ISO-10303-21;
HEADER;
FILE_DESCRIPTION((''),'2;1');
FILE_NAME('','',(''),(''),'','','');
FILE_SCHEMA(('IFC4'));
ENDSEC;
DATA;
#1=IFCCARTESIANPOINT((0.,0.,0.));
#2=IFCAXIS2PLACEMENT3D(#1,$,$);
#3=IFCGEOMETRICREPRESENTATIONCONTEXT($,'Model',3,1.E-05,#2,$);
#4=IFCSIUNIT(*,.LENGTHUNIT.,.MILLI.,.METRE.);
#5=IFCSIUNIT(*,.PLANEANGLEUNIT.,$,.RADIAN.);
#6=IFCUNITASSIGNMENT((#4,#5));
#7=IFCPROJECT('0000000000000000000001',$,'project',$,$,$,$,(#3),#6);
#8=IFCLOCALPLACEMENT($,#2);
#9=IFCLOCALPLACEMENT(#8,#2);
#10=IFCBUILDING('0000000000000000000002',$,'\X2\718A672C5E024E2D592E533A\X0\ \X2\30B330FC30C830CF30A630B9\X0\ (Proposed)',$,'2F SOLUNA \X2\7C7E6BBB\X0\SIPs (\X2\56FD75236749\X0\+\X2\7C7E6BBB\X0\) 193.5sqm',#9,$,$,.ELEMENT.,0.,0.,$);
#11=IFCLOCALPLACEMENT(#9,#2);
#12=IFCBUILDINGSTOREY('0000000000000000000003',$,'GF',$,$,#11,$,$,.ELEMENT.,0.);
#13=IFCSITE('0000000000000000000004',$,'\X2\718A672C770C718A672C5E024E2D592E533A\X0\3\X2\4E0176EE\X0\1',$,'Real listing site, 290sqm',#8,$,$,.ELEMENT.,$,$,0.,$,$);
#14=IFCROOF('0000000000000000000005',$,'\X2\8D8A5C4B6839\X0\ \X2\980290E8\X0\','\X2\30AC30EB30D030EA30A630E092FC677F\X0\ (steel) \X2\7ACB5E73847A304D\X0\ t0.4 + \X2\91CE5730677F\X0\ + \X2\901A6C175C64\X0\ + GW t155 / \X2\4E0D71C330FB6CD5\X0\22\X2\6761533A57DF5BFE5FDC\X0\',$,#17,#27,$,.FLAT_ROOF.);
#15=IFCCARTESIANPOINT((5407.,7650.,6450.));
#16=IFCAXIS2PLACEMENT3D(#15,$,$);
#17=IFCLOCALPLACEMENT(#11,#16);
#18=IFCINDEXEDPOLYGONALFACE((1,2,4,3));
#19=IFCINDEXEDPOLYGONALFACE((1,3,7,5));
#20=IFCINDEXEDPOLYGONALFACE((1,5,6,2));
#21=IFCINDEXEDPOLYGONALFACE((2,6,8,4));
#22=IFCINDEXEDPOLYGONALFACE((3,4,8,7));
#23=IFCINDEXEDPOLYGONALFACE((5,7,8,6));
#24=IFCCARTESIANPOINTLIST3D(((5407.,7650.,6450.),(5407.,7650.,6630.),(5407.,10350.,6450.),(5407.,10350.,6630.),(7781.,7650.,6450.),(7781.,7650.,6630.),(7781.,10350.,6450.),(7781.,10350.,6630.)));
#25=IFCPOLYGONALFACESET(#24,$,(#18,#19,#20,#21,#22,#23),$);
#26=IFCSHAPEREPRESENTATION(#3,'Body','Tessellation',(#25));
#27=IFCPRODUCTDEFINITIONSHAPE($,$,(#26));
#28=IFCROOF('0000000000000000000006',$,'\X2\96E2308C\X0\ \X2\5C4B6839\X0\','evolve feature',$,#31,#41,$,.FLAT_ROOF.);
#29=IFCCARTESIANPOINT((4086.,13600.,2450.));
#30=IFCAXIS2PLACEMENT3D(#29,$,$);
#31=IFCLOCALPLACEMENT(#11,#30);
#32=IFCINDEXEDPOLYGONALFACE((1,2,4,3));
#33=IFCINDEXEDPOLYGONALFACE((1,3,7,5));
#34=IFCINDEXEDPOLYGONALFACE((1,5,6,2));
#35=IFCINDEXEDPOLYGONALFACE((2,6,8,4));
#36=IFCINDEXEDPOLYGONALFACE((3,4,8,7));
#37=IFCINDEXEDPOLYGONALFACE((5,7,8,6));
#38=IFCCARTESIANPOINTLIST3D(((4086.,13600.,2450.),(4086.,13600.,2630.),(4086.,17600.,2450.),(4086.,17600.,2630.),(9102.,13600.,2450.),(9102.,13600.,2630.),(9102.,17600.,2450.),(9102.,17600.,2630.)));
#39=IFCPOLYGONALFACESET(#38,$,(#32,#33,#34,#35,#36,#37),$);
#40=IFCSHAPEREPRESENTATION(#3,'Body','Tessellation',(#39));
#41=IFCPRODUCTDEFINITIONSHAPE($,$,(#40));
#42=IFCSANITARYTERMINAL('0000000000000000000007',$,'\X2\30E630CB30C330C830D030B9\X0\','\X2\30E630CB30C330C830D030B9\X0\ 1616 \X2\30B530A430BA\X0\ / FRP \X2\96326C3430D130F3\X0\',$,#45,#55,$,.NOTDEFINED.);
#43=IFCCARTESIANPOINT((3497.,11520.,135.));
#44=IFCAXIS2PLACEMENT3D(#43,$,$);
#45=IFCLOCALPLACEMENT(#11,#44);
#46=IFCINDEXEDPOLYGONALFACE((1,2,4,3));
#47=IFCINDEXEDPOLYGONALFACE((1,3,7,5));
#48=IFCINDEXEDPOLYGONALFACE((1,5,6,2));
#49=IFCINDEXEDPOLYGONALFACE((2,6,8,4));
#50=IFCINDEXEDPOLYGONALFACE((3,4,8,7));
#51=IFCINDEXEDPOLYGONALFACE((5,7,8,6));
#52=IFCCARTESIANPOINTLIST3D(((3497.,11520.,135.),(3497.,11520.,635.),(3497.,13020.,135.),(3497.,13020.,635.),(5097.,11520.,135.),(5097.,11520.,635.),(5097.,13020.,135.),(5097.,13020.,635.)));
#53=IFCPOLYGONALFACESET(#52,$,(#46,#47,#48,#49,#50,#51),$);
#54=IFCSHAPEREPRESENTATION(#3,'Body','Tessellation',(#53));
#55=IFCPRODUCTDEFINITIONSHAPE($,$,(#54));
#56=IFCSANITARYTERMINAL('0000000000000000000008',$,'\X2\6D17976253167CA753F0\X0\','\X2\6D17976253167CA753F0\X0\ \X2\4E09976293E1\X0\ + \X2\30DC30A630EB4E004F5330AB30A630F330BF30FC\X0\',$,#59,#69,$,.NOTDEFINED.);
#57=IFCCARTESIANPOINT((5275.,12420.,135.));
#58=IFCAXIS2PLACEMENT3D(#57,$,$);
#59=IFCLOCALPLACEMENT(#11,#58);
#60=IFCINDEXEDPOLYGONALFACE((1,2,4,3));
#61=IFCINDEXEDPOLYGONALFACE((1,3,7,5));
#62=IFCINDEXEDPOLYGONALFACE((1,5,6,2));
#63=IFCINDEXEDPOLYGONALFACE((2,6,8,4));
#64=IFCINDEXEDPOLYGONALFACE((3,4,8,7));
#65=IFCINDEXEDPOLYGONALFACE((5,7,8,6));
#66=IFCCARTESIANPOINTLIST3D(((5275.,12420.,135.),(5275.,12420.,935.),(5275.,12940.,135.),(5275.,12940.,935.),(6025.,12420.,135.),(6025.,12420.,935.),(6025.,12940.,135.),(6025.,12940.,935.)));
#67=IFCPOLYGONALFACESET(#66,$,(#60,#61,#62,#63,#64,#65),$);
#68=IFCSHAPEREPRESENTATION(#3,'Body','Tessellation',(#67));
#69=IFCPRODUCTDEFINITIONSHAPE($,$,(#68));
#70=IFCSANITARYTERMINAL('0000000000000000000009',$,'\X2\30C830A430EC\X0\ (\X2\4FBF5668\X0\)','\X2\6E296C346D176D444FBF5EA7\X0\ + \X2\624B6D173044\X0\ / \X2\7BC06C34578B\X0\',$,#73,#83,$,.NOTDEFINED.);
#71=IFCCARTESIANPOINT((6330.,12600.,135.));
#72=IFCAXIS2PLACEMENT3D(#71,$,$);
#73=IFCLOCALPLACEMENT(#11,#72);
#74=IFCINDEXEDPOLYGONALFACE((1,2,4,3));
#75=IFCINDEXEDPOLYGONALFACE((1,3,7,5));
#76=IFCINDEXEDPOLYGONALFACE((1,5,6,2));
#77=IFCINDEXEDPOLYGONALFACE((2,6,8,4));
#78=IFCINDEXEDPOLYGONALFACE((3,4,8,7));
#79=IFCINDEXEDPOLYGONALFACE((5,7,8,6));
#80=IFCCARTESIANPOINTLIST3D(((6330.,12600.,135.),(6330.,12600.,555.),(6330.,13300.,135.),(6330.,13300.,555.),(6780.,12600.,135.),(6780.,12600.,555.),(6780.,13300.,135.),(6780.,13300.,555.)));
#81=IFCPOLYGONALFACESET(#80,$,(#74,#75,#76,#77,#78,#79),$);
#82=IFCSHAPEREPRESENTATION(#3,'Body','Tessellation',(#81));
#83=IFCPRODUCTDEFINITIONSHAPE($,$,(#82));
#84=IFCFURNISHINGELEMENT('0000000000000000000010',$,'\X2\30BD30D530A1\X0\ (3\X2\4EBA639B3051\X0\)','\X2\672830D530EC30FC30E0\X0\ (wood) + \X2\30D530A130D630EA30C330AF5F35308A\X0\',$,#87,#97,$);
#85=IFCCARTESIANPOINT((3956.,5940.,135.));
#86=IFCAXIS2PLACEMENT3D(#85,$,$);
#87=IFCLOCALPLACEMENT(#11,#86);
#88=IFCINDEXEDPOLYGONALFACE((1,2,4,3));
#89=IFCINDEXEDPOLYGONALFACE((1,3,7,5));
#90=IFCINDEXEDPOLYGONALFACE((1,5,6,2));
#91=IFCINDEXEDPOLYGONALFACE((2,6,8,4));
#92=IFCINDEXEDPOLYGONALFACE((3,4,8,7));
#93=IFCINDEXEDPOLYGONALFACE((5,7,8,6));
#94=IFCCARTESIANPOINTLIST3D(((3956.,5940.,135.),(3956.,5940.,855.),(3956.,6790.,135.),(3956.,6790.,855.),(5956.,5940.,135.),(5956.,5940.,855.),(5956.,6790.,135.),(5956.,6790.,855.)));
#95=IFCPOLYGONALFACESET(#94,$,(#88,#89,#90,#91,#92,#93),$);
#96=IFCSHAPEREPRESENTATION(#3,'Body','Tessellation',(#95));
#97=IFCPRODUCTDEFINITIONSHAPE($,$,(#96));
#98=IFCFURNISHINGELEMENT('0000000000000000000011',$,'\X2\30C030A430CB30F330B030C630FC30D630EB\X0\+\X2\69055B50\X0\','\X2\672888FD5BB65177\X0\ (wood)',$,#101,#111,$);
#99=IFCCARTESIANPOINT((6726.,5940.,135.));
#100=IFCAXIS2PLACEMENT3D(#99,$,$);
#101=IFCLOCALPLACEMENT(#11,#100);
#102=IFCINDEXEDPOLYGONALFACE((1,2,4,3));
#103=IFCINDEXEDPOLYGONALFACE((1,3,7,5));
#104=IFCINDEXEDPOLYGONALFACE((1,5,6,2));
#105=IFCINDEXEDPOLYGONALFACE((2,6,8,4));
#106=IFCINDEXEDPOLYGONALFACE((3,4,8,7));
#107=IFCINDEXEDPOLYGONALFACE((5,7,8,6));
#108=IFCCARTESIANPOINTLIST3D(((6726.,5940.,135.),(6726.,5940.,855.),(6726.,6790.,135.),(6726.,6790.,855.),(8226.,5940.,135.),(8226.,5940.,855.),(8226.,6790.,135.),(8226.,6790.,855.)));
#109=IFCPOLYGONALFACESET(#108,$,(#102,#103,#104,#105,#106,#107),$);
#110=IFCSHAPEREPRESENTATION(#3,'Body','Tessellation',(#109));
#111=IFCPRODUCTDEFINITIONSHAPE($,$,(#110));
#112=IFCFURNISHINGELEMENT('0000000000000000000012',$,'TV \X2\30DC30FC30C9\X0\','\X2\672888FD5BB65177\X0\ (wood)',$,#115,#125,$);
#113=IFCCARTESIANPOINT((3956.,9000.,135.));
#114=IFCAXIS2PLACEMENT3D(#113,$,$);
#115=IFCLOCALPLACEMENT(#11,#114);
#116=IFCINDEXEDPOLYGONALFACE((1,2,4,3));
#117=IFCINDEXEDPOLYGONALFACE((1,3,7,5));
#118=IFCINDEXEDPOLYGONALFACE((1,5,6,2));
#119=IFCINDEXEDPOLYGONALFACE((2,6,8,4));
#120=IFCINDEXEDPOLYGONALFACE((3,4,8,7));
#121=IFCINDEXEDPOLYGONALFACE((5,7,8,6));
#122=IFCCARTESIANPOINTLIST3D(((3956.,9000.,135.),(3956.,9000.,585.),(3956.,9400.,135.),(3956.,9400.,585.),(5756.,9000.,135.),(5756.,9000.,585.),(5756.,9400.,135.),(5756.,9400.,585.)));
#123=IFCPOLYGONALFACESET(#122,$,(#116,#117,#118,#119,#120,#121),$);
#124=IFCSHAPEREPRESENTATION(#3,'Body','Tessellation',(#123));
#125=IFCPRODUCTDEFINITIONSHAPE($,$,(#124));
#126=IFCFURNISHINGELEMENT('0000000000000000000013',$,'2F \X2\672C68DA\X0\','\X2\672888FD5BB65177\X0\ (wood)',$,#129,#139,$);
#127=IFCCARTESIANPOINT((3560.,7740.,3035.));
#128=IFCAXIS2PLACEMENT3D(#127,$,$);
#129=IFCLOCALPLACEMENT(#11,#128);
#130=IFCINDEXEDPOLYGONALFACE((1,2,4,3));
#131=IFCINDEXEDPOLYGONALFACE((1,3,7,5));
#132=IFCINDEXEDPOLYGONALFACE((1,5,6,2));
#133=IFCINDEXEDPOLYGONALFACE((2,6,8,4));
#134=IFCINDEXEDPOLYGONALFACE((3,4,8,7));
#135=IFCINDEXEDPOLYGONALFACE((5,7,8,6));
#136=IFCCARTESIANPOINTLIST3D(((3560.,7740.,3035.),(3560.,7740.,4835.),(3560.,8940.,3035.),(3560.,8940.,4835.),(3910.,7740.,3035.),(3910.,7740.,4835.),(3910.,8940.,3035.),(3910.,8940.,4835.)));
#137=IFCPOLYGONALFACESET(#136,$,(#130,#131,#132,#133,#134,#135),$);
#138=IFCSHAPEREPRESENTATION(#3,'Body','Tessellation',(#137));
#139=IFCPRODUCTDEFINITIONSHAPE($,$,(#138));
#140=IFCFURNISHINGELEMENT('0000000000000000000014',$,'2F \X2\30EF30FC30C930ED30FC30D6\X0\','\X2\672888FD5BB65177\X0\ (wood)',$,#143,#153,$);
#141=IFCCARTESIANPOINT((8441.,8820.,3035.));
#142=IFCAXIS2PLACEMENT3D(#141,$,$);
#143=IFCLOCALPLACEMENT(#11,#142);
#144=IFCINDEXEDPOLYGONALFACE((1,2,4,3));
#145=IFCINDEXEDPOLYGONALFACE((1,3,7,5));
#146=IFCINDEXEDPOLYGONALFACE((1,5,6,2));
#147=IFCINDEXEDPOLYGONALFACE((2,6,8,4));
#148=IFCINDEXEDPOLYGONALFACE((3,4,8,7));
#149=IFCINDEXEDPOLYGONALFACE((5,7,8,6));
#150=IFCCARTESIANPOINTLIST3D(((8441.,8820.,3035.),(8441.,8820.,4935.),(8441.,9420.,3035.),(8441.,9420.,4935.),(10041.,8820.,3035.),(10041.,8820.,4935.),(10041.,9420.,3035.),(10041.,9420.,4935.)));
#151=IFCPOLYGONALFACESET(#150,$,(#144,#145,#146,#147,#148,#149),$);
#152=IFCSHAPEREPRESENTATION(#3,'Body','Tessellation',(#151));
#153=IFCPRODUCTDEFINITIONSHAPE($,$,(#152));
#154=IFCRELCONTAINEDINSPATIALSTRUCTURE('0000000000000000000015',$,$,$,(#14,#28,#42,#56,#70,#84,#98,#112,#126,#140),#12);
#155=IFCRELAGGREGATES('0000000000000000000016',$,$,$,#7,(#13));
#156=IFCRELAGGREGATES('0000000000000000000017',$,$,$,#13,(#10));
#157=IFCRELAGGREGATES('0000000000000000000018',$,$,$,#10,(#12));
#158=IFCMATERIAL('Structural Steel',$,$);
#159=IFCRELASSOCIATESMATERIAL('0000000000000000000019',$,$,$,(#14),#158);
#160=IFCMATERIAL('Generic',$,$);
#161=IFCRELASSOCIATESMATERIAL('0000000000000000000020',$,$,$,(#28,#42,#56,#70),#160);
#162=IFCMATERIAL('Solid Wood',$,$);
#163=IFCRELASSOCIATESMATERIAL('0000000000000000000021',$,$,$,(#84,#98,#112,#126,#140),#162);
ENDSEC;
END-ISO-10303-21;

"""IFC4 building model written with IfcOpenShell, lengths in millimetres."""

from ifc_helpers import new_model, si_unit, frame, frame_2d, origin, place, context, project, spatial, rectangle, extrude, material, element, save


model = new_model("IFC4")

# Units and contexts
model_context = context("Model", 3, precision=1e-05, world=origin())
ifc_project = project(units=[si_unit("LENGTHUNIT", "METRE", prefix="MILLI"), si_unit("PLANEANGLEUNIT", "RADIAN")], contexts=[model_context])

# Site, building, storey
site_placement = place(None, origin())
site = spatial("IfcSite", under=ifc_project, at=site_placement, Name="熊本県熊本市中央区3丁目1", ObjectType="Real listing site, 290sqm", CompositionType="ELEMENT", RefElevation=0.0)
building_placement = place(site_placement, origin())
building = spatial("IfcBuilding", under=site, at=building_placement, Name="熊本市中央区 コートハウス (Proposed)", ObjectType="2F SOLUNA 籾殻SIPs (国産杉+籾殻) 193.5sqm", CompositionType="ELEMENT", ElevationOfRefHeight=0.0, ElevationOfTerrain=0.0)
storey_placement = place(building_placement, origin())
storey = spatial("IfcBuildingStorey", under=building, at=storey_placement, Name="GF", CompositionType="ELEMENT", Elevation=0.0)

# Shared definitions
ifc_material_1 = material(Name="Generic")

# Shared definitions
ifc_material_2 = material(Name="Solid Wood")

# Roofs
ifc_material_3 = material(Name="Structural Steel")
roof_1_placement = place(storey_placement, frame((5407.0, 7650.0, 6450.0)))
element("IfcRoof", 1, at=roof_1_placement, inside=storey, material=ifc_material_3, Name="越屋根 頂部", Description="ガルバリウム鋼板 (steel) 立平葺き t0.4 + 野地板 + 通気層 + GW t155 / 不燃・法22条区域対応", PredefinedType="FLAT_ROOF", context=model_context, shape_type="SweptSolid", body=[
    extrude(rectangle(XDim=2374.0, YDim=2700.0, at=frame_2d((1187.0, 1350.0))), frame((5407.0, 7650.0, 6450.0)), (0.0, 0.0, 1.0), 180.0),
])
roof_2_placement = place(storey_placement, frame((4086.0, 13600.0, 2450.0)))
element("IfcRoof", 2, at=roof_2_placement, inside=storey, material=ifc_material_1, Name="離れ 屋根", Description="evolve feature", PredefinedType="FLAT_ROOF", context=model_context, shape_type="SweptSolid", body=[
    extrude(rectangle(XDim=5016.0, YDim=4000.0, at=frame_2d((2508.0, 2000.0))), frame((4086.0, 13600.0, 2450.0)), (0.0, 0.0, 1.0), 180.0),
])

# Sanitary terminals
sanitary_terminal_1_placement = place(storey_placement, frame((3497.0, 11520.0, 135.0)))
element("IfcSanitaryTerminal", 3, at=sanitary_terminal_1_placement, inside=storey, material=ifc_material_1, Name="ユニットバス", Description="ユニットバス 1616 サイズ / FRP 防水パン", PredefinedType="NOTDEFINED", context=model_context, shape_type="SweptSolid", body=[
    extrude(rectangle(XDim=1600.0, YDim=1500.0, at=frame_2d((800.0, 750.0))), frame((3497.0, 11520.0, 135.0)), (0.0, 0.0, 1.0), 500.0),
])
sanitary_terminal_2_placement = place(storey_placement, frame((5275.0, 12420.0, 135.0)))
element("IfcSanitaryTerminal", 4, at=sanitary_terminal_2_placement, inside=storey, material=ifc_material_1, Name="洗面化粧台", Description="洗面化粧台 三面鏡 + ボウル一体カウンター", PredefinedType="NOTDEFINED", context=model_context, shape_type="SweptSolid", body=[
    extrude(rectangle(XDim=750.0, YDim=520.0, at=frame_2d((375.0, 260.0))), frame((5275.0, 12420.0, 135.0)), (0.0, 0.0, 1.0), 800.0),
])
sanitary_terminal_3_placement = place(storey_placement, frame((6330.0, 12600.0, 135.0)))
element("IfcSanitaryTerminal", 5, at=sanitary_terminal_3_placement, inside=storey, material=ifc_material_1, Name="トイレ (便器)", Description="温水洗浄便座 + 手洗い / 節水型", PredefinedType="NOTDEFINED", context=model_context, shape_type="SweptSolid", body=[
    extrude(rectangle(XDim=450.0, YDim=700.0, at=frame_2d((225.0, 350.0))), frame((6330.0, 12600.0, 135.0)), (0.0, 0.0, 1.0), 420.0),
])

# Furnishing elements
furnishing_1_placement = place(storey_placement, frame((3956.0, 5940.0, 135.0)))
element("IfcFurnishingElement", 6, at=furnishing_1_placement, inside=storey, material=ifc_material_2, Name="ソファ (3人掛け)", Description="木フレーム (wood) + ファブリック張り", context=model_context, shape_type="SweptSolid", body=[
    extrude(rectangle(XDim=2000.0, YDim=850.0, at=frame_2d((1000.0, 425.0))), frame((3956.0, 5940.0, 135.0)), (0.0, 0.0, 1.0), 720.0),
])
furnishing_2_placement = place(storey_placement, frame((6726.0, 5940.0, 135.0)))
element("IfcFurnishingElement", 7, at=furnishing_2_placement, inside=storey, material=ifc_material_2, Name="ダイニングテーブル+椅子", Description="木製家具 (wood)", context=model_context, shape_type="SweptSolid", body=[
    extrude(rectangle(XDim=1500.0, YDim=850.0, at=frame_2d((750.0, 425.0))), frame((6726.0, 5940.0, 135.0)), (0.0, 0.0, 1.0), 720.0),
])
furnishing_3_placement = place(storey_placement, frame((3956.0, 9000.0, 135.0)))
element("IfcFurnishingElement", 8, at=furnishing_3_placement, inside=storey, material=ifc_material_2, Name="TV ボード", Description="木製家具 (wood)", context=model_context, shape_type="SweptSolid", body=[
    extrude(rectangle(XDim=1800.0, YDim=400.0, at=frame_2d((900.0, 200.0))), frame((3956.0, 9000.0, 135.0)), (0.0, 0.0, 1.0), 450.0),
])
furnishing_4_placement = place(storey_placement, frame((3560.0, 7740.0, 3035.0)))
element("IfcFurnishingElement", 9, at=furnishing_4_placement, inside=storey, material=ifc_material_2, Name="2F 本棚", Description="木製家具 (wood)", context=model_context, shape_type="SweptSolid", body=[
    extrude(rectangle(XDim=350.0, YDim=1200.0, at=frame_2d((175.0, 600.0))), frame((3560.0, 7740.0, 3035.0)), (0.0, 0.0, 1.0), 1800.0),
])
furnishing_5_placement = place(storey_placement, frame((8441.0, 8820.0, 3035.0)))
element("IfcFurnishingElement", 10, at=furnishing_5_placement, inside=storey, material=ifc_material_2, Name="2F ワードローブ", Description="木製家具 (wood)", context=model_context, shape_type="SweptSolid", body=[
    extrude(rectangle(XDim=1600.0, YDim=600.0, at=frame_2d((800.0, 300.0))), frame((8441.0, 8820.0, 3035.0)), (0.0, 0.0, 1.0), 1900.0),
])

save(model, "model.ifc")
